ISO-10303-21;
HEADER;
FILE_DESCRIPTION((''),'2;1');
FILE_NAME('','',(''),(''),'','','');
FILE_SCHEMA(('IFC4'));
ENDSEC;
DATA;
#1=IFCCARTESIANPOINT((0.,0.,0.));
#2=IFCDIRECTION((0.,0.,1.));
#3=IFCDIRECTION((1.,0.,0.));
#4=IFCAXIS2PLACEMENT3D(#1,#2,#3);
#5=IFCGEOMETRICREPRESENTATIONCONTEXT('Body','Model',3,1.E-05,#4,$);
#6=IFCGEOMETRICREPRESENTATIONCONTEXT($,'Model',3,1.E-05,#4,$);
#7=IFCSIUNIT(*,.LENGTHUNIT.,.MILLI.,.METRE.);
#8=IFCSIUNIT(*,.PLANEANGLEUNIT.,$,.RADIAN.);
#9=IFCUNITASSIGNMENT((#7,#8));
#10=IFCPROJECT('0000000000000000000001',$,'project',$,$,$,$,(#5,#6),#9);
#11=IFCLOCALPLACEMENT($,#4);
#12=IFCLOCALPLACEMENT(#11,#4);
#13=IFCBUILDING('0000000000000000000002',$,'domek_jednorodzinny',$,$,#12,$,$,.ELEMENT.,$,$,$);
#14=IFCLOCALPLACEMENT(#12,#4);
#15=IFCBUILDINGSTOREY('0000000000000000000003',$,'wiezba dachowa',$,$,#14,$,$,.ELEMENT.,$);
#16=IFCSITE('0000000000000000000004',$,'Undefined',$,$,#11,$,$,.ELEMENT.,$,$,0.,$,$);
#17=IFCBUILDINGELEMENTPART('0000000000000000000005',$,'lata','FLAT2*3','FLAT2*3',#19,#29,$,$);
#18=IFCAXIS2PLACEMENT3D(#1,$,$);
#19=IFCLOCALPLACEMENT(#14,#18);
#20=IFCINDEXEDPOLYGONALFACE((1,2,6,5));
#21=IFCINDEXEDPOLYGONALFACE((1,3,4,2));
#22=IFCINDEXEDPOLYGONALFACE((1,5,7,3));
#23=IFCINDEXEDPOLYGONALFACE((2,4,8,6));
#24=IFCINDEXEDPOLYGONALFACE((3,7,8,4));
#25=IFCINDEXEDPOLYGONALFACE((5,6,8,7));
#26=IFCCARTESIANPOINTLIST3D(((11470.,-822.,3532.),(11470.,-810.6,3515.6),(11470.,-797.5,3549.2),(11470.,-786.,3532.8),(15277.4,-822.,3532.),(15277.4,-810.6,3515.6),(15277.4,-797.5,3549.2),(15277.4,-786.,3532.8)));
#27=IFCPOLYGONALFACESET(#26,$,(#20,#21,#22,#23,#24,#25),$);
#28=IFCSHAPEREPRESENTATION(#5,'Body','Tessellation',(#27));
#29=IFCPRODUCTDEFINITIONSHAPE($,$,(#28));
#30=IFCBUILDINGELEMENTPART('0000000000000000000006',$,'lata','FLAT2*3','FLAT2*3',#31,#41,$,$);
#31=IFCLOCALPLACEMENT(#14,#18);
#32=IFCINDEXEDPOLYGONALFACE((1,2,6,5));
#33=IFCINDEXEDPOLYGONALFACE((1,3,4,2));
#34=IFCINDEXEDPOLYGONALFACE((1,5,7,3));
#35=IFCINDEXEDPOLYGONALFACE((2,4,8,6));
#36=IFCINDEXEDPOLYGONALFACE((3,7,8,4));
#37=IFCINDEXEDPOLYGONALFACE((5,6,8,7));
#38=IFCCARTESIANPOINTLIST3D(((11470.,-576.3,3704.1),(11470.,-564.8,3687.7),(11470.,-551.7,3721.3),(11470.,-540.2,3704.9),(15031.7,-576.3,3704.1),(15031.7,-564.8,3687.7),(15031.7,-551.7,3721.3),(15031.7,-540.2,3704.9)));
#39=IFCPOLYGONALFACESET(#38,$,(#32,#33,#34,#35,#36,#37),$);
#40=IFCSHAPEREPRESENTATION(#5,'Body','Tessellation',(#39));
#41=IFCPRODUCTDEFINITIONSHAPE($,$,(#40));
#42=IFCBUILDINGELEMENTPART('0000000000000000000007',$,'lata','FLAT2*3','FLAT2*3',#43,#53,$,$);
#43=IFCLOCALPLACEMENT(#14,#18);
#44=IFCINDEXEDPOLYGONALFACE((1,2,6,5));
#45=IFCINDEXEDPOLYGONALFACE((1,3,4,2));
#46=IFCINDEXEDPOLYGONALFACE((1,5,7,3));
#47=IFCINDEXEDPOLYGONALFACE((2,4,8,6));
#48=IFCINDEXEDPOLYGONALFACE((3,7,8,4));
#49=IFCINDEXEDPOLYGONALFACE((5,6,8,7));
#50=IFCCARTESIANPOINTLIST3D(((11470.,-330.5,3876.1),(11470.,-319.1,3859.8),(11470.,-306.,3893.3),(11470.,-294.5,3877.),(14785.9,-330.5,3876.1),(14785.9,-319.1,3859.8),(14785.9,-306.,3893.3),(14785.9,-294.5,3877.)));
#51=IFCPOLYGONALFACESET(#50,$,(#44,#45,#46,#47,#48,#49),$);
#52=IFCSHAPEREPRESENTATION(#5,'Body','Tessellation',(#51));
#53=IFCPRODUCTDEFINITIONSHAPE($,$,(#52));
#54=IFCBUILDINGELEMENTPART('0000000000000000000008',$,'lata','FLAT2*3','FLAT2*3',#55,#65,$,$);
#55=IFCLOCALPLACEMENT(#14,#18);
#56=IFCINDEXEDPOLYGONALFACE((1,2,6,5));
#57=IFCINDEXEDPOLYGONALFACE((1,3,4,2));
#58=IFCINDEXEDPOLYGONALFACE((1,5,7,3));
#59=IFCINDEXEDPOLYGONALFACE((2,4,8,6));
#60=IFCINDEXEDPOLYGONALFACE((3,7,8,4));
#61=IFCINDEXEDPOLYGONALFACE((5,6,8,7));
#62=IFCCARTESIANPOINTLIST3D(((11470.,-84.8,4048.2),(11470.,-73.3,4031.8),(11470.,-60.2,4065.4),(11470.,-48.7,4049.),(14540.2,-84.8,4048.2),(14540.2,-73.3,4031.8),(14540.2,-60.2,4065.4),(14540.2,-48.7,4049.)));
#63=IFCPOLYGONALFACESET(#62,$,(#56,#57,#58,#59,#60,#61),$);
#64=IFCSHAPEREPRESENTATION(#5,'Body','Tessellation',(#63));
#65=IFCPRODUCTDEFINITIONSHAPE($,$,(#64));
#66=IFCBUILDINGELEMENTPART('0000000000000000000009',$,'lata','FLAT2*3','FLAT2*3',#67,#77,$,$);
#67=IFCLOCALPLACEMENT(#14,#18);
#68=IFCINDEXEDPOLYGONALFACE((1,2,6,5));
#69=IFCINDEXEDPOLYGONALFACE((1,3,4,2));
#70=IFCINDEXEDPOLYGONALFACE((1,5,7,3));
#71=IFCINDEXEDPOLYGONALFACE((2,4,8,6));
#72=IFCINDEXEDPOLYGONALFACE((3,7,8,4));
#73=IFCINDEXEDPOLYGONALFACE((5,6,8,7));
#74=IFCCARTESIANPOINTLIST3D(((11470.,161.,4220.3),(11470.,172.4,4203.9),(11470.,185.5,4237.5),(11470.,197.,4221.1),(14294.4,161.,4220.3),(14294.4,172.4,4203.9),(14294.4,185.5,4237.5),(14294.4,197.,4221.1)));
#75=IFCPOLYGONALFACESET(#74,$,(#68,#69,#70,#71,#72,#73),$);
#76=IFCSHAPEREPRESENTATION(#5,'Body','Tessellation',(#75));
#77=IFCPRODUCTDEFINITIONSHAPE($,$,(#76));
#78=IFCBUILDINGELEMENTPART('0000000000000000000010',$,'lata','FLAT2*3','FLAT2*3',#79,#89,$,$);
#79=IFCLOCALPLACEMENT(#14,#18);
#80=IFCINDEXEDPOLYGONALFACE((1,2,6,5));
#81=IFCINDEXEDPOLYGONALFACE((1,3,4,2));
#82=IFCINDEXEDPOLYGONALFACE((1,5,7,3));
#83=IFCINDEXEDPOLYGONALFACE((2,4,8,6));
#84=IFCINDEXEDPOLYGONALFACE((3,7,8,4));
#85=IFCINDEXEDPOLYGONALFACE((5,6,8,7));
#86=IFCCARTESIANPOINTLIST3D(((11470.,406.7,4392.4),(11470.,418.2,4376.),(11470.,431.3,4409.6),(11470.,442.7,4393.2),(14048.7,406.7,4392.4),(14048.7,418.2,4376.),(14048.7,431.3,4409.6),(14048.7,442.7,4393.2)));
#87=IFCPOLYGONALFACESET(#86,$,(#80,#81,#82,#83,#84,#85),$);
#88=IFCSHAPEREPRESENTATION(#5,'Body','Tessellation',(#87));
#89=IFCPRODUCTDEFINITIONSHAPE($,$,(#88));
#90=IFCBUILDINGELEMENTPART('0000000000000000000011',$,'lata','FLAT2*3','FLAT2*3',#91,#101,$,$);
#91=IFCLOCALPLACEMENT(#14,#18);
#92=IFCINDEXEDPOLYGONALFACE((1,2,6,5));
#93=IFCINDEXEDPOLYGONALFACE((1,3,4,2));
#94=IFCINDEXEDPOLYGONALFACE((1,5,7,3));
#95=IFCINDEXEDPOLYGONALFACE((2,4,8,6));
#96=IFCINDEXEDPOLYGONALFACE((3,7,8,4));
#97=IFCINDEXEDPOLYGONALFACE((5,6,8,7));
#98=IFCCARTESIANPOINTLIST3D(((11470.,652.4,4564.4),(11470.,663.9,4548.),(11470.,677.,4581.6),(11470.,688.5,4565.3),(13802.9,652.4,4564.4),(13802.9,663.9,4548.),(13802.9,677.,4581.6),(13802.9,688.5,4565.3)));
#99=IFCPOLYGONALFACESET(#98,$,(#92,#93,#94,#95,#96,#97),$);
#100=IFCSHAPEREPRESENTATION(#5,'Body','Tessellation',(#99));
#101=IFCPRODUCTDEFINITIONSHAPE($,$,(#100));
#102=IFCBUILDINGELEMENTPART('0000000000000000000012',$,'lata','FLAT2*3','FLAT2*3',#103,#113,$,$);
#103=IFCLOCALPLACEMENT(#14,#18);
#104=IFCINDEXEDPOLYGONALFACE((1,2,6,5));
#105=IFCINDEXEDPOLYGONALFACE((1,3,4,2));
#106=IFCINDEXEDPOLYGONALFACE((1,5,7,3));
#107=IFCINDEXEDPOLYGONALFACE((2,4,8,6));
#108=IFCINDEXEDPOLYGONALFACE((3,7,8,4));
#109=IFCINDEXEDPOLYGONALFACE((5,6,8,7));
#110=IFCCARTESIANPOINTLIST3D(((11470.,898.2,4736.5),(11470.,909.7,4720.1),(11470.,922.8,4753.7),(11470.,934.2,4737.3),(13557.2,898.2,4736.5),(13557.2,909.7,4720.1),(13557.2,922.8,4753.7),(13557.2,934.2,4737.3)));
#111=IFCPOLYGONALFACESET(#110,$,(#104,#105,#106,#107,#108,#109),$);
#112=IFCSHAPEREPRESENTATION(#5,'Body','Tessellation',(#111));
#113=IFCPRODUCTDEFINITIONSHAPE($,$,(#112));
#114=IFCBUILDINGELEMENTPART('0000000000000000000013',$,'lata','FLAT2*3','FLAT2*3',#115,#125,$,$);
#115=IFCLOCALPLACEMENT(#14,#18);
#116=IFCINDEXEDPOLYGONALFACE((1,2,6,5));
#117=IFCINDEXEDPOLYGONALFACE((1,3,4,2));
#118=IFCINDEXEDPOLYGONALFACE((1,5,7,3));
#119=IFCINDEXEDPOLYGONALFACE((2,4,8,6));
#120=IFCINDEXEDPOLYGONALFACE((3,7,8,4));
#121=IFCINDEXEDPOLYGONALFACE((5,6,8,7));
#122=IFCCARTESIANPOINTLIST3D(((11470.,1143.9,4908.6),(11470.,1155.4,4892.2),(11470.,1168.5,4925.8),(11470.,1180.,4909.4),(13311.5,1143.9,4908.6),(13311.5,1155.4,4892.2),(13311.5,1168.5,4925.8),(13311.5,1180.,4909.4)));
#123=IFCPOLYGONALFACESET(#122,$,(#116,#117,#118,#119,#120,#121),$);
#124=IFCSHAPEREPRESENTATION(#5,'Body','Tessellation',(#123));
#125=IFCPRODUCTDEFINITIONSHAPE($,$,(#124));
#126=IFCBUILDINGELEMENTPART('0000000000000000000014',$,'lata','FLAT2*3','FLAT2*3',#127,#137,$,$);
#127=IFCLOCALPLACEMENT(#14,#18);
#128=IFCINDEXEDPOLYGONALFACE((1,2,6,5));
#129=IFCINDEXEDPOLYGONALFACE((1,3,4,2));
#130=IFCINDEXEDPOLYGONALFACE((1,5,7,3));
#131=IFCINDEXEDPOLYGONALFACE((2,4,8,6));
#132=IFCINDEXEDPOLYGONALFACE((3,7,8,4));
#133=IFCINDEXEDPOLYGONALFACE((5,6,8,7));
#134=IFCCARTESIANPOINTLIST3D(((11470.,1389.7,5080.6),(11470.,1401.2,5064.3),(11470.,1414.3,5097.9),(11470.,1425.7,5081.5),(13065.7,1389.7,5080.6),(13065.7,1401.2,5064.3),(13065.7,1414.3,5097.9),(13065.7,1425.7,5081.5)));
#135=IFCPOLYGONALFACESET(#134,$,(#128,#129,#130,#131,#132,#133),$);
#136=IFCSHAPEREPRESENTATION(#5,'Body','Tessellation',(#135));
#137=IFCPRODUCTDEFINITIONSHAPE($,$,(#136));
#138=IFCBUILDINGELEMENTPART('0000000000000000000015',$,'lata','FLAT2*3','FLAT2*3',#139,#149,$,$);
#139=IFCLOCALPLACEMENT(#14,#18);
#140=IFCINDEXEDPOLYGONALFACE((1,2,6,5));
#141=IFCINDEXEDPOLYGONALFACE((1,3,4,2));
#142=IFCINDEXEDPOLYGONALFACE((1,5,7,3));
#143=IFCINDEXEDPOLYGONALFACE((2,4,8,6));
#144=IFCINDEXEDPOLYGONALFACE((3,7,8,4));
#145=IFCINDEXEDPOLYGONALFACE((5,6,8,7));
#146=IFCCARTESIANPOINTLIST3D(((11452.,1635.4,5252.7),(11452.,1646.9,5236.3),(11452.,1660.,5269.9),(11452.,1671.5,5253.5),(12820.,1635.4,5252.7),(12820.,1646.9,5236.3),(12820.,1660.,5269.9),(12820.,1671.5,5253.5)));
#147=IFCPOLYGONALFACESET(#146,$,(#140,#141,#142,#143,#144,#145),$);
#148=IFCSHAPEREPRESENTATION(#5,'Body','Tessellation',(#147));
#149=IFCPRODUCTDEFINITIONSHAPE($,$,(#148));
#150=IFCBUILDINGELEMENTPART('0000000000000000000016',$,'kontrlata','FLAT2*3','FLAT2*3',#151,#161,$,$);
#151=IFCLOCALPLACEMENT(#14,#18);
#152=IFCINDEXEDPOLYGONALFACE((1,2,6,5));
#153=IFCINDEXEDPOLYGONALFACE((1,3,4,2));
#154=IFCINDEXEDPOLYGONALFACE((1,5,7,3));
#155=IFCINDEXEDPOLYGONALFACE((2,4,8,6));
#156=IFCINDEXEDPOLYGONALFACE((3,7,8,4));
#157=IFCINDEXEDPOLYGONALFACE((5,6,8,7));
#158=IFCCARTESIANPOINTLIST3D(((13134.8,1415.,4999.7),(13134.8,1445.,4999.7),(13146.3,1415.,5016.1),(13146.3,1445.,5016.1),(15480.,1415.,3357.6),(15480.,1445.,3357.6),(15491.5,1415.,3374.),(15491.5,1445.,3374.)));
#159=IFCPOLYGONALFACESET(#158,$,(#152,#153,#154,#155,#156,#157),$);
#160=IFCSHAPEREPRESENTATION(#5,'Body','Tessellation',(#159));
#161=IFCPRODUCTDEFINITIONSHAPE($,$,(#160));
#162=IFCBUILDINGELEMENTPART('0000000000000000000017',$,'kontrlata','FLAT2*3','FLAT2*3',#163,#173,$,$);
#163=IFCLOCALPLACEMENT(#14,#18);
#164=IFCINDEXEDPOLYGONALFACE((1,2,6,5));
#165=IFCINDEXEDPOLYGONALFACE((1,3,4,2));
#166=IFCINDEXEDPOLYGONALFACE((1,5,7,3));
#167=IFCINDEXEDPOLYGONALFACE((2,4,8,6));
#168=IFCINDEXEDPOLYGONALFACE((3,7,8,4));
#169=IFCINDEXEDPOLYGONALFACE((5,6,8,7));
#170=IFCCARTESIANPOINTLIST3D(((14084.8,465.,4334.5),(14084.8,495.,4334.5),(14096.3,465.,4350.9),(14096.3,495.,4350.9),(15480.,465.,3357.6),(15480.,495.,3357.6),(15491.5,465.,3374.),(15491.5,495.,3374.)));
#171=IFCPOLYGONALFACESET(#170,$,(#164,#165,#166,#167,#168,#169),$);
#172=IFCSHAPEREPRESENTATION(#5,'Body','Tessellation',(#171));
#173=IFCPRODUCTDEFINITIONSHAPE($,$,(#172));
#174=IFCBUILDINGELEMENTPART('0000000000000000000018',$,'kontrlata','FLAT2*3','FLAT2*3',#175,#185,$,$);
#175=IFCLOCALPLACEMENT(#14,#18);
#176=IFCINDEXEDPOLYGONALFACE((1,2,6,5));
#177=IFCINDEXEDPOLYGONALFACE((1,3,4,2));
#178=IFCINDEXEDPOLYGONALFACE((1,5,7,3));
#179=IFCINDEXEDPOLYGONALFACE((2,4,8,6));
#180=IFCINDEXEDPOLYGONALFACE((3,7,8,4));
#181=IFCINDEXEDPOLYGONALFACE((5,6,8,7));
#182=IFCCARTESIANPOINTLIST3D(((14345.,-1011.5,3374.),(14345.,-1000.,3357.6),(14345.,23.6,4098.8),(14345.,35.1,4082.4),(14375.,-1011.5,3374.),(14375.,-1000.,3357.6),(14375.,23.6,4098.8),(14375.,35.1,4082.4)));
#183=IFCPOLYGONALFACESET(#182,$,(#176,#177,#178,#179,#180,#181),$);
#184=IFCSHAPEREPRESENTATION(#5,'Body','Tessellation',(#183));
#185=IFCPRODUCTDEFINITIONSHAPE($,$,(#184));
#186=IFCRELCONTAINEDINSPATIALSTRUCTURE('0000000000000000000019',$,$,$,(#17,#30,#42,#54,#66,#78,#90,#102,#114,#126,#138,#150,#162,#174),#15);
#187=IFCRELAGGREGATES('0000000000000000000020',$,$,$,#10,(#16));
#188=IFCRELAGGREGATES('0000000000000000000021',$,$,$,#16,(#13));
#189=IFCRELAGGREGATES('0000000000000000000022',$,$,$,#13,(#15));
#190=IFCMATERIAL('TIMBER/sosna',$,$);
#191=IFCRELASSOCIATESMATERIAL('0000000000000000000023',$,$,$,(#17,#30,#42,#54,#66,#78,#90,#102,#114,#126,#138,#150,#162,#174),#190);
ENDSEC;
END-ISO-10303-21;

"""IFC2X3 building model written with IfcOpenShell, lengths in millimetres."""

from ifc_helpers import new_model, si_unit, frame, origin_with_axes, origin_2d_with_axis, place, context, project, spatial, rectangle, extrude, material, element, save


model = new_model("IFC2X3")

# Units and contexts
model_context_1 = context("Model", 3, precision=1e-05, world=origin_with_axes(), identifier="Body")
model_context_2 = context("Model", 3, precision=1e-05, world=origin_with_axes())
ifc_project = project(units=[si_unit("LENGTHUNIT", "METRE", prefix="MILLI"), si_unit("PLANEANGLEUNIT", "RADIAN")], contexts=[model_context_1, model_context_2])

# Site, building, storey
site_placement = place(None, origin_with_axes())
site = spatial("IfcSite", under=ifc_project, at=site_placement, Name="Undefined", CompositionType="ELEMENT", RefElevation=0.0)
building_placement = place(site_placement, origin_with_axes())
building = spatial("IfcBuilding", under=site, at=building_placement, Name="domek_jednorodzinny", CompositionType="ELEMENT")
storey_placement = place(building_placement, origin_with_axes())
storey = spatial("IfcBuildingStorey", under=building, at=storey_placement, Name="wiezba dachowa", CompositionType="ELEMENT")

# Building element parts
ifc_material = material(Name="TIMBER/sosna")
building_element_part_1_placement = place(storey_placement, frame((11470.0, -804.0, 3532.4), z_axis=(0.0, 0.819154, 0.573574), x_axis=(1.0, 0.0, 0.0)))
element("IfcBuildingElementPart", 1, at=building_element_part_1_placement, inside=storey, material=ifc_material, Name="lata", Description="FLAT2*3", ObjectType="FLAT2*3", context=model_context_1, shape_type="SweptSolid", body=[
    extrude(rectangle(XDim=20.0, YDim=30.0, at=origin_2d_with_axis()), frame((3807.4, 0.0, 0.0), z_axis=(-1.0, 0.0, 0.0), x_axis=(0.0, -1.0, 0.0)), (0.0, 0.0, 1.0), 3807.4),
])
building_element_part_2_placement = place(storey_placement, frame((11470.0, -558.3, 3704.5), z_axis=(0.0, 0.819154, 0.573574), x_axis=(1.0, 0.0, 0.0)))
element("IfcBuildingElementPart", 2, at=building_element_part_2_placement, inside=storey, material=ifc_material, Name="lata", Description="FLAT2*3", ObjectType="FLAT2*3", context=model_context_1, shape_type="SweptSolid", body=[
    extrude(rectangle(XDim=20.0, YDim=30.0, at=origin_2d_with_axis()), frame((3561.7, 0.0, 0.0), z_axis=(-1.0, 0.0, 0.0), x_axis=(0.0, -1.0, 0.0)), (0.0, 0.0, 1.0), 3561.7),
])
building_element_part_3_placement = place(storey_placement, frame((11470.0, -312.5, 3876.5), z_axis=(0.0, 0.819154, 0.573574), x_axis=(1.0, 0.0, 0.0)))
element("IfcBuildingElementPart", 3, at=building_element_part_3_placement, inside=storey, material=ifc_material, Name="lata", Description="FLAT2*3", ObjectType="FLAT2*3", context=model_context_1, shape_type="SweptSolid", body=[
    extrude(rectangle(XDim=20.0, YDim=30.0, at=origin_2d_with_axis()), frame((3316.0, 0.0, 0.0), z_axis=(-1.0, 0.0, 0.0), x_axis=(0.0, -1.0, 0.0)), (0.0, 0.0, 1.0), 3316.0),
])
building_element_part_4_placement = place(storey_placement, frame((11470.0, -66.8, 4048.6), z_axis=(0.0, 0.819154, 0.573574), x_axis=(1.0, 0.0, 0.0)))
element("IfcBuildingElementPart", 4, at=building_element_part_4_placement, inside=storey, material=ifc_material, Name="lata", Description="FLAT2*3", ObjectType="FLAT2*3", context=model_context_1, shape_type="SweptSolid", body=[
    extrude(rectangle(XDim=20.0, YDim=30.0, at=origin_2d_with_axis()), frame((3070.2, 0.0, 0.0), z_axis=(-1.0, 0.0, 0.0), x_axis=(0.0, -1.0, 0.0)), (0.0, 0.0, 1.0), 3070.2),
])
building_element_part_5_placement = place(storey_placement, frame((11470.0, 179.0, 4220.7), z_axis=(0.0, 0.819154, 0.573574), x_axis=(1.0, 0.0, 0.0)))
element("IfcBuildingElementPart", 5, at=building_element_part_5_placement, inside=storey, material=ifc_material, Name="lata", Description="FLAT2*3", ObjectType="FLAT2*3", context=model_context_1, shape_type="SweptSolid", body=[
    extrude(rectangle(XDim=20.0, YDim=30.0, at=origin_2d_with_axis()), frame((2824.5, 0.0, 0.0), z_axis=(-1.0, 0.0, 0.0), x_axis=(0.0, -1.0, 0.0)), (0.0, 0.0, 1.0), 2824.5),
])
building_element_part_6_placement = place(storey_placement, frame((11470.0, 424.7, 4392.8), z_axis=(0.0, 0.819154, 0.573574), x_axis=(1.0, 0.0, 0.0)))
element("IfcBuildingElementPart", 6, at=building_element_part_6_placement, inside=storey, material=ifc_material, Name="lata", Description="FLAT2*3", ObjectType="FLAT2*3", context=model_context_1, shape_type="SweptSolid", body=[
    extrude(rectangle(XDim=20.0, YDim=30.0, at=origin_2d_with_axis()), frame((2578.7, 0.0, 0.0), z_axis=(-1.0, 0.0, 0.0), x_axis=(0.0, -1.0, 0.0)), (0.0, 0.0, 1.0), 2578.7),
])
building_element_part_7_placement = place(storey_placement, frame((11470.0, 670.5, 4564.8), z_axis=(0.0, 0.819154, 0.573574), x_axis=(1.0, 0.0, 0.0)))
element("IfcBuildingElementPart", 7, at=building_element_part_7_placement, inside=storey, material=ifc_material, Name="lata", Description="FLAT2*3", ObjectType="FLAT2*3", context=model_context_1, shape_type="SweptSolid", body=[
    extrude(rectangle(XDim=20.0, YDim=30.0, at=origin_2d_with_axis()), frame((2333.0, 0.0, 0.0), z_axis=(-1.0, 0.0, 0.0), x_axis=(0.0, -1.0, 0.0)), (0.0, 0.0, 1.0), 2333.0),
])
building_element_part_8_placement = place(storey_placement, frame((11470.0, 916.2, 4736.9), z_axis=(0.0, 0.819154, 0.573574), x_axis=(1.0, 0.0, 0.0)))
element("IfcBuildingElementPart", 8, at=building_element_part_8_placement, inside=storey, material=ifc_material, Name="lata", Description="FLAT2*3", ObjectType="FLAT2*3", context=model_context_1, shape_type="SweptSolid", body=[
    extrude(rectangle(XDim=20.0, YDim=30.0, at=origin_2d_with_axis()), frame((2087.2, 0.0, 0.0), z_axis=(-1.0, 0.0, 0.0), x_axis=(0.0, -1.0, 0.0)), (0.0, 0.0, 1.0), 2087.2),
])
building_element_part_9_placement = place(storey_placement, frame((11470.0, 1162.0, 4909.0), z_axis=(0.0, 0.819154, 0.573574), x_axis=(1.0, 0.0, 0.0)))
element("IfcBuildingElementPart", 9, at=building_element_part_9_placement, inside=storey, material=ifc_material, Name="lata", Description="FLAT2*3", ObjectType="FLAT2*3", context=model_context_1, shape_type="SweptSolid", body=[
    extrude(rectangle(XDim=20.0, YDim=30.0, at=origin_2d_with_axis()), frame((1841.5, 0.0, 0.0), z_axis=(-1.0, 0.0, 0.0), x_axis=(0.0, -1.0, 0.0)), (0.0, 0.0, 1.0), 1841.5),
])
building_element_part_10_placement = place(storey_placement, frame((11470.0, 1407.7, 5081.1), z_axis=(0.0, 0.819154, 0.573574), x_axis=(1.0, 0.0, 0.0)))
element("IfcBuildingElementPart", 10, at=building_element_part_10_placement, inside=storey, material=ifc_material, Name="lata", Description="FLAT2*3", ObjectType="FLAT2*3", context=model_context_1, shape_type="SweptSolid", body=[
    extrude(rectangle(XDim=20.0, YDim=30.0, at=origin_2d_with_axis()), frame((1595.8, 0.0, 0.0), z_axis=(-1.0, 0.0, 0.0), x_axis=(0.0, -1.0, 0.0)), (0.0, 0.0, 1.0), 1595.8),
])
building_element_part_11_placement = place(storey_placement, frame((11452.0, 1653.4, 5253.1), z_axis=(0.0, 0.819154, 0.573574), x_axis=(1.0, 0.0, 0.0)))
element("IfcBuildingElementPart", 11, at=building_element_part_11_placement, inside=storey, material=ifc_material, Name="lata", Description="FLAT2*3", ObjectType="FLAT2*3", context=model_context_1, shape_type="SweptSolid", body=[
    extrude(rectangle(XDim=20.0, YDim=30.0, at=origin_2d_with_axis()), frame((1368.0, 0.0, 0.0), z_axis=(-1.0, 0.0, 0.0), x_axis=(0.0, -1.0, 0.0)), (0.0, 0.0, 1.0), 1368.0),
])
building_element_part_12_placement = place(storey_placement, frame((15485.7, 1430.0, 3365.8), z_axis=(0.0, -1.0, 0.0), x_axis=(-0.819152, 0.0, 0.573576)))
element("IfcBuildingElementPart", 12, at=building_element_part_12_placement, inside=storey, material=ifc_material, Name="kontrlata", Description="FLAT2*3", ObjectType="FLAT2*3", context=model_context_1, shape_type="SweptSolid", body=[
    extrude(rectangle(XDim=20.0, YDim=30.0, at=origin_2d_with_axis()), frame((2862.9, 0.0, 0.0), z_axis=(-1.0, 0.0, 0.0), x_axis=(0.0, -1.0, 0.0)), (0.0, 0.0, 1.0), 2862.9),
])
building_element_part_13_placement = place(storey_placement, frame((15485.7, 480.0, 3365.8), z_axis=(0.0, -1.0, 0.0), x_axis=(-0.819152, 0.0, 0.573576)))
element("IfcBuildingElementPart", 13, at=building_element_part_13_placement, inside=storey, material=ifc_material, Name="kontrlata", Description="FLAT2*3", ObjectType="FLAT2*3", context=model_context_1, shape_type="SweptSolid", body=[
    extrude(rectangle(XDim=20.0, YDim=30.0, at=origin_2d_with_axis()), frame((1703.2, 0.0, 0.0), z_axis=(-1.0, 0.0, 0.0), x_axis=(0.0, -1.0, 0.0)), (0.0, 0.0, 1.0), 1703.2),
])
building_element_part_14_placement = place(storey_placement, frame((14360.0, -1005.7, 3365.8), z_axis=(-1.0, 0.0, 0.0), x_axis=(0.0, 0.819154, 0.573574)))
element("IfcBuildingElementPart", 14, at=building_element_part_14_placement, inside=storey, material=ifc_material, Name="kontrlata", Description="FLAT2*3", ObjectType="FLAT2*3", context=model_context_1, shape_type="SweptSolid", body=[
    extrude(rectangle(XDim=20.0, YDim=30.0, at=origin_2d_with_axis()), frame((1263.6, 0.0, 0.0), z_axis=(-1.0, 0.0, 0.0), x_axis=(0.0, -1.0, 0.0)), (0.0, 0.0, 1.0), 1263.6),
])

save(model, "model.ifc")
